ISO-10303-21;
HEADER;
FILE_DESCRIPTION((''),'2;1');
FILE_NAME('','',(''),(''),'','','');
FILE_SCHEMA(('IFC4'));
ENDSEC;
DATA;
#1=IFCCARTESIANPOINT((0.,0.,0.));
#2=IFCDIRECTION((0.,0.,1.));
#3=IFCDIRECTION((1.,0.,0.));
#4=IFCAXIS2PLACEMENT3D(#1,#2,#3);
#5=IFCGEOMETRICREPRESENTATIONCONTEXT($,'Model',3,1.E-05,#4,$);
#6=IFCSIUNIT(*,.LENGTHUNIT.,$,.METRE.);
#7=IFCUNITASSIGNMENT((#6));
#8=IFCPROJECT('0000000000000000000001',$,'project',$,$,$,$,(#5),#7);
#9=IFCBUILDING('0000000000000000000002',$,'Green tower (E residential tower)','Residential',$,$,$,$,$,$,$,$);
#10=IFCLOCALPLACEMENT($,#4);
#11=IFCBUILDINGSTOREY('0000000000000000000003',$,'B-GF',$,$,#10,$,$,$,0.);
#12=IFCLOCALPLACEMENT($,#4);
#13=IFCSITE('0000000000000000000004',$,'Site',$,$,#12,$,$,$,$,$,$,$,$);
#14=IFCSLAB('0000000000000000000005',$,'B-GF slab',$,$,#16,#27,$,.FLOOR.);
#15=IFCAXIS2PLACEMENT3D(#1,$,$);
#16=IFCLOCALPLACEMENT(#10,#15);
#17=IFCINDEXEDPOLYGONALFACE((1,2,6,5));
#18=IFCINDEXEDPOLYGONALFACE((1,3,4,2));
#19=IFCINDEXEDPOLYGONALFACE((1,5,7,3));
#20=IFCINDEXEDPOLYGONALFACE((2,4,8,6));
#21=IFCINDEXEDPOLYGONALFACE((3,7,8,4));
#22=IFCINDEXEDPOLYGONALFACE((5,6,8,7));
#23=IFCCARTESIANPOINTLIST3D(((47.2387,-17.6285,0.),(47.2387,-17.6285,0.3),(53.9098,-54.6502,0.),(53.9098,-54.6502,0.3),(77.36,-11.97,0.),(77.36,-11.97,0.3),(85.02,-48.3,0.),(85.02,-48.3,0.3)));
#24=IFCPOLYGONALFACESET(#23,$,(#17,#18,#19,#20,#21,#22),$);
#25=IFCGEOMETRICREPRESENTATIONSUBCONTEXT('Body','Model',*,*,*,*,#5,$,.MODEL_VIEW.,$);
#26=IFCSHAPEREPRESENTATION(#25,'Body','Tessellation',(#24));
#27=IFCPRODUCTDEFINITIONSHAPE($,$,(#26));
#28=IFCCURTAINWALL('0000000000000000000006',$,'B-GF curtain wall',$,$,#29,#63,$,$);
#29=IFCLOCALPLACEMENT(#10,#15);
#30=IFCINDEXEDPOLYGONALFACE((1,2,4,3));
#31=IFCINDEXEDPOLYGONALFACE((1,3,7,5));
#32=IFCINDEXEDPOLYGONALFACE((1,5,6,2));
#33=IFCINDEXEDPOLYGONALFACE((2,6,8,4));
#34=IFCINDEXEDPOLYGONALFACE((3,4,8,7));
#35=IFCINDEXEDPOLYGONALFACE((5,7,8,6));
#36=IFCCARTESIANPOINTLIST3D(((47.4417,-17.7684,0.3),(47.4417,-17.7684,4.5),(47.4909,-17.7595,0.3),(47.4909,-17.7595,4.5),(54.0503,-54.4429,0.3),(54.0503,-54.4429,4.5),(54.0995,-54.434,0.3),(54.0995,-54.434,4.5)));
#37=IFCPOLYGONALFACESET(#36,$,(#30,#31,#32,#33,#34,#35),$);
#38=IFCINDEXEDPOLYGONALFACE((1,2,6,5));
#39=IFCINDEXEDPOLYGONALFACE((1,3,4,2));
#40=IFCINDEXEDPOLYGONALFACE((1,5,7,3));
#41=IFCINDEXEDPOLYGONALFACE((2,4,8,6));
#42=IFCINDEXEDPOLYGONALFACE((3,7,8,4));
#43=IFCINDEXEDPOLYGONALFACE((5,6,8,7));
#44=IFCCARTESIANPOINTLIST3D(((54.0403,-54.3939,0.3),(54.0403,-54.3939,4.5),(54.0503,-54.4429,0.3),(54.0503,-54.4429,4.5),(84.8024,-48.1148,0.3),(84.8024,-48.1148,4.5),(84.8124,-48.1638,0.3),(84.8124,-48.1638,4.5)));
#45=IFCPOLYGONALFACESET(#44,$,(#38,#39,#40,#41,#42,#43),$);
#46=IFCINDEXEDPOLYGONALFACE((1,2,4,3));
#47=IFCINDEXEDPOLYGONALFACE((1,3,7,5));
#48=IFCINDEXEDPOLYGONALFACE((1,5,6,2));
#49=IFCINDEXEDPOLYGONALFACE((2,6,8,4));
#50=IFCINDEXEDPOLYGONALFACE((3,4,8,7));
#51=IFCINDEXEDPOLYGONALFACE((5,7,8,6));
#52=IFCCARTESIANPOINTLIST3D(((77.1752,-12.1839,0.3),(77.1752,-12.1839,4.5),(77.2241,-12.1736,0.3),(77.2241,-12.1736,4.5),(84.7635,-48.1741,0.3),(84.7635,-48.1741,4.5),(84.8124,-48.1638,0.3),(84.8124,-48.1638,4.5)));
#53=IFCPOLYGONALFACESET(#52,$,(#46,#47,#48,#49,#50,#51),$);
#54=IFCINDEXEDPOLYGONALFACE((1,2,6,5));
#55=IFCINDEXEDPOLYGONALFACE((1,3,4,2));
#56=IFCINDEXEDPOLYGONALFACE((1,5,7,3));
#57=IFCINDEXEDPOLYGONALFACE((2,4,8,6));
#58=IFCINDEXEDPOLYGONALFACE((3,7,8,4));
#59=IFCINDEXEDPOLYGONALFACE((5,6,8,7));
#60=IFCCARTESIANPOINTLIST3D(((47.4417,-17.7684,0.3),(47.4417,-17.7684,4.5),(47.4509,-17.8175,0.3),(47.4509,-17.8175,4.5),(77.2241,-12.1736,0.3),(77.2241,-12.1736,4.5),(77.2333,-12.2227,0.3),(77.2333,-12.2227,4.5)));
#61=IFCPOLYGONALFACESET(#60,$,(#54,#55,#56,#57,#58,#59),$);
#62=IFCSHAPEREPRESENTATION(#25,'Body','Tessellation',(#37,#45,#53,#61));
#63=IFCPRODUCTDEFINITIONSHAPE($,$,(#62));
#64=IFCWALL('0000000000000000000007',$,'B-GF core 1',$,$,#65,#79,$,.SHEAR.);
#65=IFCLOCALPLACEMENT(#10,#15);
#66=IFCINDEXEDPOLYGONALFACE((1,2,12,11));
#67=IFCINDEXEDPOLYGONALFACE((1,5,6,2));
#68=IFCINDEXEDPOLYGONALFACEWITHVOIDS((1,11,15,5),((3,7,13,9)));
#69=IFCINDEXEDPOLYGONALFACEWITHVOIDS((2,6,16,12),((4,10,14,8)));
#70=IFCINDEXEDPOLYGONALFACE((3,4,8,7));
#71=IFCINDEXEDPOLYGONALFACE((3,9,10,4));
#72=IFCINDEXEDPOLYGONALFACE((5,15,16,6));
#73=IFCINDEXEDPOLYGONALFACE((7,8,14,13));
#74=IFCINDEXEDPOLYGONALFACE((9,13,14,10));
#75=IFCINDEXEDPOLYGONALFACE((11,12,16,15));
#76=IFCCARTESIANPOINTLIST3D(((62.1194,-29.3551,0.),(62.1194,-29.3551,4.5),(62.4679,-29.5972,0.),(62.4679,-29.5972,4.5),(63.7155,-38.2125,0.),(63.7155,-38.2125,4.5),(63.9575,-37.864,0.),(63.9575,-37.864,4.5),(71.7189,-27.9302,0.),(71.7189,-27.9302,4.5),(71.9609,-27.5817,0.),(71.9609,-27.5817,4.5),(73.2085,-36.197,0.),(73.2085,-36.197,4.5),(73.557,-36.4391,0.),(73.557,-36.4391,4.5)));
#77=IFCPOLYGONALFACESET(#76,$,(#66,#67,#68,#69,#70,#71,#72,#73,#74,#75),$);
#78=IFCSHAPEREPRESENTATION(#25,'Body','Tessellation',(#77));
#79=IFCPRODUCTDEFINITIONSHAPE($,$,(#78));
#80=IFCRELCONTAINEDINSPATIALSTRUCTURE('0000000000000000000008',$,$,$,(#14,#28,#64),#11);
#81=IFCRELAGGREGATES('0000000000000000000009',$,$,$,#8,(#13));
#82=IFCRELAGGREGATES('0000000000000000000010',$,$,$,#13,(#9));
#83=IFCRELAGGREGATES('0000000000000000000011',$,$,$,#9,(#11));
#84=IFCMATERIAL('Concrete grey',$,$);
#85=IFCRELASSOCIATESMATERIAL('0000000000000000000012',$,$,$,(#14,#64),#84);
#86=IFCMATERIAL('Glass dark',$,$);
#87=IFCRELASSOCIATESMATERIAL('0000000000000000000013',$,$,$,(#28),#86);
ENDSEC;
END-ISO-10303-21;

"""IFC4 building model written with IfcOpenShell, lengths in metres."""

from ifc_helpers import new_model, si_unit, frame, origin_with_axes, place, context, subcontext, project, spatial, polyline, outline, extrude, material, element, save


model = new_model("IFC4")

# Units and contexts
model_context = context("Model", 3, precision=1e-05, world=origin_with_axes())
body_context = subcontext(model_context, "Body", "Model", "MODEL_VIEW")
ifc_project = project(units=[si_unit("LENGTHUNIT", "METRE")], contexts=[model_context])

# Site, building, storey
site_placement = place(None, origin_with_axes())
site = spatial("IfcSite", under=ifc_project, at=site_placement, Name="Site")
building = spatial("IfcBuilding", under=site, Name="Green tower (E residential tower)", Description="Residential")
storey_placement = place(None, origin_with_axes())
storey = spatial("IfcBuildingStorey", under=building, at=storey_placement, Name="B-GF", Elevation=0.0)

# Slab
ifc_material_1 = material(Name="Concrete grey")
slab_placement = place(storey_placement, origin_with_axes())
element("IfcSlab", 1, at=slab_placement, inside=storey, material=ifc_material_1, Name="B-GF slab", PredefinedType="FLOOR", context=body_context, shape_type="SweptSolid", body=[
    extrude(outline(polyline([(47.2387, -17.6285), (53.9098, -54.6502), (85.02, -48.3), (77.36, -11.97), (47.2387, -17.6285)])), origin_with_axes(), (0.0, 0.0, 1.0), 0.3),
])

# Curtain wall
ifc_material_2 = material(Name="Glass dark")
curtain_wall_placement = place(storey_placement, origin_with_axes())
element("IfcCurtainWall", 2, at=curtain_wall_placement, inside=storey, material=ifc_material_2, Name="B-GF curtain wall", context=body_context, shape_type="SweptSolid", body=[
    extrude(outline(polyline([(47.4417, -17.7684), (54.0503, -54.4429), (54.0995, -54.434), (47.4909, -17.7595), (47.4417, -17.7684)])), frame((0.0, 0.0, 0.3), z_axis=(0.0, 0.0, 1.0), x_axis=(1.0, 0.0, 0.0)), (0.0, 0.0, 1.0), 4.2),
    extrude(outline(polyline([(54.0503, -54.4429), (84.8124, -48.1638), (84.8024, -48.1148), (54.0403, -54.3939), (54.0503, -54.4429)])), frame((0.0, 0.0, 0.3), z_axis=(0.0, 0.0, 1.0), x_axis=(1.0, 0.0, 0.0)), (0.0, 0.0, 1.0), 4.2),
    extrude(outline(polyline([(84.8124, -48.1638), (77.2241, -12.1736), (77.1752, -12.1839), (84.7635, -48.1741), (84.8124, -48.1638)])), frame((0.0, 0.0, 0.3), z_axis=(0.0, 0.0, 1.0), x_axis=(1.0, 0.0, 0.0)), (0.0, 0.0, 1.0), 4.2),
    extrude(outline(polyline([(77.2241, -12.1736), (47.4417, -17.7684), (47.4509, -17.8175), (77.2333, -12.2227), (77.2241, -12.1736)])), frame((0.0, 0.0, 0.3), z_axis=(0.0, 0.0, 1.0), x_axis=(1.0, 0.0, 0.0)), (0.0, 0.0, 1.0), 4.2),
])

# Wall
wall_placement = place(storey_placement, origin_with_axes())
element("IfcWall", 3, at=wall_placement, inside=storey, material=ifc_material_1, Name="B-GF core 1", PredefinedType="SHEAR", context=body_context, shape_type="SweptSolid", body=[
    extrude(outline(polyline([(62.1194, -29.3551), (63.7155, -38.2125), (73.557, -36.4391), (71.9609, -27.5817), (62.1194, -29.3551)]), holes=[polyline([(62.4679, -29.5972), (63.9575, -37.864), (73.2085, -36.197), (71.7189, -27.9302), (62.4679, -29.5972)])]), origin_with_axes(), (0.0, 0.0, 1.0), 4.5),
])

save(model, "model.ifc")
